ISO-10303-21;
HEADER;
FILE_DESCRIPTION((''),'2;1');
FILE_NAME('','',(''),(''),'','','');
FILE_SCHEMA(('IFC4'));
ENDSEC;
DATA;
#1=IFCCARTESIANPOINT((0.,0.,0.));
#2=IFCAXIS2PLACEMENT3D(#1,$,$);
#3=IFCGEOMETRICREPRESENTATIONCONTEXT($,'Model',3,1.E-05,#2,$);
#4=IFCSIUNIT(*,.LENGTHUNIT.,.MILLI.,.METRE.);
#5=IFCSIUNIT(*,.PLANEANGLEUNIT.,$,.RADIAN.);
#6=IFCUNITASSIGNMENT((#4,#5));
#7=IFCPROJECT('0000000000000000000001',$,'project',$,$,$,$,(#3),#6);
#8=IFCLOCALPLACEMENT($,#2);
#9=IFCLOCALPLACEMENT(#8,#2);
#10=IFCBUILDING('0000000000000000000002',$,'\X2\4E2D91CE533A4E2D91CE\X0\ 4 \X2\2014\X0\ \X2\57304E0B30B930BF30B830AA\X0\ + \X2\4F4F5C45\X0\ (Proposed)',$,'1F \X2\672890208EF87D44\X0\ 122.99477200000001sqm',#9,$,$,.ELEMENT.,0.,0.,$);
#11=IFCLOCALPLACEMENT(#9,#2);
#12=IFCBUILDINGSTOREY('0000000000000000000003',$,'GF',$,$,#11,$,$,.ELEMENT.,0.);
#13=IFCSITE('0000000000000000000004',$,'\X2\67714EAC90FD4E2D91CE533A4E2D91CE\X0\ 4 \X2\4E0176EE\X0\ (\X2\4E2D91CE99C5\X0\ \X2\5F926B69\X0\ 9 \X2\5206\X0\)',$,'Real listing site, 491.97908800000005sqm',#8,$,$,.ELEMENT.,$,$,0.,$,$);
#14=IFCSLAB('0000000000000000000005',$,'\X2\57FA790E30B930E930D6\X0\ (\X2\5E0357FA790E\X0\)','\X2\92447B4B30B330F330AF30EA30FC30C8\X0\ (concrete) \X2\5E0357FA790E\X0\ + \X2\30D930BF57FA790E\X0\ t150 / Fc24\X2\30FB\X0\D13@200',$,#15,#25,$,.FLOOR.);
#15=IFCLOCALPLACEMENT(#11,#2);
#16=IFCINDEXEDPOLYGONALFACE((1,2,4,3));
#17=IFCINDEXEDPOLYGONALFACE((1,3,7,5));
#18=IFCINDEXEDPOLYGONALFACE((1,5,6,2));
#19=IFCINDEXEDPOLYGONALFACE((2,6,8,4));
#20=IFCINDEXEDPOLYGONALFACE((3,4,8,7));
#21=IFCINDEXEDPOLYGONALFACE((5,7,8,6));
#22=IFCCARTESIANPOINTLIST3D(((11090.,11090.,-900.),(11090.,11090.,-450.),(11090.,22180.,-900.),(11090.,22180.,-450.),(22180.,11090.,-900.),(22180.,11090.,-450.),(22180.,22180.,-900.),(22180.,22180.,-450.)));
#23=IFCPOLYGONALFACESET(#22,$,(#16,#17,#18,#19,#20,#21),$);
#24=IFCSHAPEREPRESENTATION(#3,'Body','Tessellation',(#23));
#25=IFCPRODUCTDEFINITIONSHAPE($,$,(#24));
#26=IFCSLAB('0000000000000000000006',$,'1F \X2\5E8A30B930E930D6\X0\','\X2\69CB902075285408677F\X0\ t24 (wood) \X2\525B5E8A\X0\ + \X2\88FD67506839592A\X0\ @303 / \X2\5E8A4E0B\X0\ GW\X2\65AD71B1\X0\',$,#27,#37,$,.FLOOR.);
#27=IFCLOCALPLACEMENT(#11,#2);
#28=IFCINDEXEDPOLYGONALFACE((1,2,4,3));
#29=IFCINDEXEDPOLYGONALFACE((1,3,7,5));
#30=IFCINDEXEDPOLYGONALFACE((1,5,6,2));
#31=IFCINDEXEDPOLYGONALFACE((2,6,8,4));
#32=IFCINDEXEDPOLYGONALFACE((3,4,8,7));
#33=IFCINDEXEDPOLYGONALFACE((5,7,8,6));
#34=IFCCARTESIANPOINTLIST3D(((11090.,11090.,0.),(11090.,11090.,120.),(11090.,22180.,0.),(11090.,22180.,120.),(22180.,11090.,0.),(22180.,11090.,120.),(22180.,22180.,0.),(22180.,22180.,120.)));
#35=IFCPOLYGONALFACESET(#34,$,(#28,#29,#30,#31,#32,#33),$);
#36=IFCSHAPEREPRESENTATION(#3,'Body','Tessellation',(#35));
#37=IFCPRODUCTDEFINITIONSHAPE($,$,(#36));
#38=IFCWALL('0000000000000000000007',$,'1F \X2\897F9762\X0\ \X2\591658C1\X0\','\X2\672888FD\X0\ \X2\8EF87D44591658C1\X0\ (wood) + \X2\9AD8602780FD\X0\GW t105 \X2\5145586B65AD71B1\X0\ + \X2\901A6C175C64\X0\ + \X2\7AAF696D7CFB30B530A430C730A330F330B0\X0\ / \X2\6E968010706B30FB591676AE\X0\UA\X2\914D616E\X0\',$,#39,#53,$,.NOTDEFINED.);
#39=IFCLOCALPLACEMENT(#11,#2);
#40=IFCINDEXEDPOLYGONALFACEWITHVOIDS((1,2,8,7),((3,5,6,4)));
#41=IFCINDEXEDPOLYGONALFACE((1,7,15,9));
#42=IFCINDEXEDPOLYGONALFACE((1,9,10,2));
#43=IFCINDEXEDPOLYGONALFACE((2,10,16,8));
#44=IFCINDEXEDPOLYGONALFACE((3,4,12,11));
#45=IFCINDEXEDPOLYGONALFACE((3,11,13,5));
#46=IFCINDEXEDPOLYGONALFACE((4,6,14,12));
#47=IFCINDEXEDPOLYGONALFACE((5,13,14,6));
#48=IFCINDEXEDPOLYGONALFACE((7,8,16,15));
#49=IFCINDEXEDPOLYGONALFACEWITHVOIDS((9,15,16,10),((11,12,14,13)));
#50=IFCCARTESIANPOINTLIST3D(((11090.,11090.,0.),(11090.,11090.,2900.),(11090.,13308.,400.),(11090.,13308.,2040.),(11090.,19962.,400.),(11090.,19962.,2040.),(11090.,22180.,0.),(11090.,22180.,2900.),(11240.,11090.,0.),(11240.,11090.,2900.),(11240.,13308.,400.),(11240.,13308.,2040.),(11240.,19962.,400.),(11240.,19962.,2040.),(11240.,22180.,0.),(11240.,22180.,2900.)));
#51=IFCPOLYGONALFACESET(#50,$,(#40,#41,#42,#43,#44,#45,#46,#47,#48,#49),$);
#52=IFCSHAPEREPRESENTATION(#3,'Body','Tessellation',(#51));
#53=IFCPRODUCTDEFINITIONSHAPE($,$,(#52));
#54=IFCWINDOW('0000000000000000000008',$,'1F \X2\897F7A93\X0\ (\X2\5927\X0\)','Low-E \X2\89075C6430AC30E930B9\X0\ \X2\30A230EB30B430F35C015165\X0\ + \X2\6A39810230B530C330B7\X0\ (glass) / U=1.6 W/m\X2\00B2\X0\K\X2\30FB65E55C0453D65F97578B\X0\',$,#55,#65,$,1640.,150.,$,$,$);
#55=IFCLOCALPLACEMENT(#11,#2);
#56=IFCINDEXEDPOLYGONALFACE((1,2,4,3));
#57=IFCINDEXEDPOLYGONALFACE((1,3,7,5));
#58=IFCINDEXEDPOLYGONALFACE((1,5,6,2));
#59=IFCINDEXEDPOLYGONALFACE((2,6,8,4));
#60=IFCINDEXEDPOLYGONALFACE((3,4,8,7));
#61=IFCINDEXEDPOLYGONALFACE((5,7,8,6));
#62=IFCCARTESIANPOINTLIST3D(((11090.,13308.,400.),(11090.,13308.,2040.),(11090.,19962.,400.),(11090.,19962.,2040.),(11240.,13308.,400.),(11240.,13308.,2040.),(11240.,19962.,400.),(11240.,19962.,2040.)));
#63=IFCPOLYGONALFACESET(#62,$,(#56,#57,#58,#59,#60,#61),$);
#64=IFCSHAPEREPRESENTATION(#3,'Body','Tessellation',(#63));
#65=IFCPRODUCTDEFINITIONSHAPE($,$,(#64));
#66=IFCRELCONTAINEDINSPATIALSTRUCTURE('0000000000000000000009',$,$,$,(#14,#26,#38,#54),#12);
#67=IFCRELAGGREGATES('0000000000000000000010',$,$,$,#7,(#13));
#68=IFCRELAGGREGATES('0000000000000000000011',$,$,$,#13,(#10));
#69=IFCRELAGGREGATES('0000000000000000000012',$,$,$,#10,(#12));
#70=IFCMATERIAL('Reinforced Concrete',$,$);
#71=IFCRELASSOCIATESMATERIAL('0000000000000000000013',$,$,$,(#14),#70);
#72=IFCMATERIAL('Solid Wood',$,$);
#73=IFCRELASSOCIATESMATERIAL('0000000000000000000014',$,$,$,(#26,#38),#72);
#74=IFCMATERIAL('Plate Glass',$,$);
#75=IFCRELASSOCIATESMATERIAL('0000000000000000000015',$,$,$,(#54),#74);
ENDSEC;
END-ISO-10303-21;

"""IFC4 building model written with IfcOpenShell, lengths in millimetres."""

from ifc_helpers import new_model, si_unit, frame, frame_2d, origin, place, context, project, spatial, rectangle, extrude, material, element, fill, save


model = new_model("IFC4")

# Units and contexts
model_context = context("Model", 3, precision=1e-05, world=origin())
ifc_project = project(units=[si_unit("LENGTHUNIT", "METRE", prefix="MILLI"), si_unit("PLANEANGLEUNIT", "RADIAN")], contexts=[model_context])

# Site, building, storey
site_placement = place(None, origin())
site = spatial("IfcSite", under=ifc_project, at=site_placement, Name="東京都中野区中野 4 丁目 (中野駅 徒歩 9 分)", ObjectType="Real listing site, 491.97908800000005sqm", CompositionType="ELEMENT", RefElevation=0.0)
building_placement = place(site_placement, origin())
building = spatial("IfcBuilding", under=site, at=building_placement, Name="中野区中野 4 — 地下スタジオ + 住居 (Proposed)", ObjectType="1F 木造軸組 122.99477200000001sqm", CompositionType="ELEMENT", ElevationOfRefHeight=0.0, ElevationOfTerrain=0.0)
storey_placement = place(building_placement, origin())
storey = spatial("IfcBuildingStorey", under=building, at=storey_placement, Name="GF", CompositionType="ELEMENT", Elevation=0.0)

# Slabs
ifc_material_1 = material(Name="Reinforced Concrete")
slab_1_placement = place(storey_placement, frame((5545.0, 5545.0, -450.0)))
element("IfcSlab", 1, at=slab_1_placement, inside=storey, material=ifc_material_1, Name="基礎スラブ (布基礎)", Description="鉄筋コンクリート (concrete) 布基礎 + ベタ基礎 t150 / Fc24・D13@200", PredefinedType="FLOOR", context=model_context, shape_type="SweptSolid", body=[
    extrude(rectangle(XDim=11090.0, YDim=11090.0, at=frame_2d((5545.0, 5545.0))), frame((5545.0, 5545.0, -450.0)), (0.0, 0.0, 1.0), 450.0),
])
ifc_material_2 = material(Name="Solid Wood")
slab_2_placement = place(storey_placement, frame((5545.0, 5545.0, 0.0)))
element("IfcSlab", 2, at=slab_2_placement, inside=storey, material=ifc_material_2, Name="1F 床スラブ", Description="構造用合板 t24 (wood) 剛床 + 製材根太 @303 / 床下 GW断熱", PredefinedType="FLOOR", context=model_context, shape_type="SweptSolid", body=[
    extrude(rectangle(XDim=11090.0, YDim=11090.0, at=frame_2d((5545.0, 5545.0))), frame((5545.0, 5545.0, 0.0)), (0.0, 0.0, 1.0), 120.0),
])

# Shared definitions
ifc_material_3 = material(Name="Plate Glass")

# Wall, opening, window
wall_1_placement = place(storey_placement, frame((5545.0, 5545.0, 0.0)))
wall_1 = element("IfcWall", 3, at=wall_1_placement, inside=storey, material=ifc_material_2, Name="1F 西面 外壁", Description="木製 軸組外壁 (wood) + 高性能GW t105 充填断熱 + 通気層 + 窯業系サイディング / 準耐火・外皮UA配慮", PredefinedType="NOTDEFINED", context=model_context, shape_type="SweptSolid", body=[
    extrude(rectangle(XDim=150.0, YDim=11090.0, at=frame_2d((75.0, 5545.0))), frame((5545.0, 5545.0, 0.0)), (0.0, 0.0, 1.0), 2900.0),
])
opening_1_placement = place(storey_placement, frame((5545.0, 6654.0, 200.0)))
opening_1 = element("IfcOpeningElement", 4, at=opening_1_placement, cuts=wall_1, PredefinedType="NOTDEFINED", context=model_context, shape_type="SweptSolid", body=[
    extrude(rectangle(XDim=150.0, YDim=6654.0, at=frame_2d((75.0, 3327.0))), frame((5545.0, 6654.0, 200.0)), (0.0, 0.0, 1.0), 1640.0),
])
window_1_placement = place(storey_placement, frame((5545.0, 6654.0, 200.0)))
window_1 = element("IfcWindow", 5, at=window_1_placement, inside=storey, material=ifc_material_3, Name="1F 西窓 (大)", Description="Low-E 複層ガラス アルゴン封入 + 樹脂サッシ (glass) / U=1.6 W/m²K・日射取得型", OverallHeight=1640.0, OverallWidth=150.0, context=model_context, shape_type="SweptSolid", body=[
    extrude(rectangle(XDim=150.0, YDim=6654.0, at=frame_2d((75.0, 3327.0))), frame((5545.0, 6654.0, 200.0)), (0.0, 0.0, 1.0), 1640.0),
])
fill(opening_1, window_1)

save(model, "model.ifc")
